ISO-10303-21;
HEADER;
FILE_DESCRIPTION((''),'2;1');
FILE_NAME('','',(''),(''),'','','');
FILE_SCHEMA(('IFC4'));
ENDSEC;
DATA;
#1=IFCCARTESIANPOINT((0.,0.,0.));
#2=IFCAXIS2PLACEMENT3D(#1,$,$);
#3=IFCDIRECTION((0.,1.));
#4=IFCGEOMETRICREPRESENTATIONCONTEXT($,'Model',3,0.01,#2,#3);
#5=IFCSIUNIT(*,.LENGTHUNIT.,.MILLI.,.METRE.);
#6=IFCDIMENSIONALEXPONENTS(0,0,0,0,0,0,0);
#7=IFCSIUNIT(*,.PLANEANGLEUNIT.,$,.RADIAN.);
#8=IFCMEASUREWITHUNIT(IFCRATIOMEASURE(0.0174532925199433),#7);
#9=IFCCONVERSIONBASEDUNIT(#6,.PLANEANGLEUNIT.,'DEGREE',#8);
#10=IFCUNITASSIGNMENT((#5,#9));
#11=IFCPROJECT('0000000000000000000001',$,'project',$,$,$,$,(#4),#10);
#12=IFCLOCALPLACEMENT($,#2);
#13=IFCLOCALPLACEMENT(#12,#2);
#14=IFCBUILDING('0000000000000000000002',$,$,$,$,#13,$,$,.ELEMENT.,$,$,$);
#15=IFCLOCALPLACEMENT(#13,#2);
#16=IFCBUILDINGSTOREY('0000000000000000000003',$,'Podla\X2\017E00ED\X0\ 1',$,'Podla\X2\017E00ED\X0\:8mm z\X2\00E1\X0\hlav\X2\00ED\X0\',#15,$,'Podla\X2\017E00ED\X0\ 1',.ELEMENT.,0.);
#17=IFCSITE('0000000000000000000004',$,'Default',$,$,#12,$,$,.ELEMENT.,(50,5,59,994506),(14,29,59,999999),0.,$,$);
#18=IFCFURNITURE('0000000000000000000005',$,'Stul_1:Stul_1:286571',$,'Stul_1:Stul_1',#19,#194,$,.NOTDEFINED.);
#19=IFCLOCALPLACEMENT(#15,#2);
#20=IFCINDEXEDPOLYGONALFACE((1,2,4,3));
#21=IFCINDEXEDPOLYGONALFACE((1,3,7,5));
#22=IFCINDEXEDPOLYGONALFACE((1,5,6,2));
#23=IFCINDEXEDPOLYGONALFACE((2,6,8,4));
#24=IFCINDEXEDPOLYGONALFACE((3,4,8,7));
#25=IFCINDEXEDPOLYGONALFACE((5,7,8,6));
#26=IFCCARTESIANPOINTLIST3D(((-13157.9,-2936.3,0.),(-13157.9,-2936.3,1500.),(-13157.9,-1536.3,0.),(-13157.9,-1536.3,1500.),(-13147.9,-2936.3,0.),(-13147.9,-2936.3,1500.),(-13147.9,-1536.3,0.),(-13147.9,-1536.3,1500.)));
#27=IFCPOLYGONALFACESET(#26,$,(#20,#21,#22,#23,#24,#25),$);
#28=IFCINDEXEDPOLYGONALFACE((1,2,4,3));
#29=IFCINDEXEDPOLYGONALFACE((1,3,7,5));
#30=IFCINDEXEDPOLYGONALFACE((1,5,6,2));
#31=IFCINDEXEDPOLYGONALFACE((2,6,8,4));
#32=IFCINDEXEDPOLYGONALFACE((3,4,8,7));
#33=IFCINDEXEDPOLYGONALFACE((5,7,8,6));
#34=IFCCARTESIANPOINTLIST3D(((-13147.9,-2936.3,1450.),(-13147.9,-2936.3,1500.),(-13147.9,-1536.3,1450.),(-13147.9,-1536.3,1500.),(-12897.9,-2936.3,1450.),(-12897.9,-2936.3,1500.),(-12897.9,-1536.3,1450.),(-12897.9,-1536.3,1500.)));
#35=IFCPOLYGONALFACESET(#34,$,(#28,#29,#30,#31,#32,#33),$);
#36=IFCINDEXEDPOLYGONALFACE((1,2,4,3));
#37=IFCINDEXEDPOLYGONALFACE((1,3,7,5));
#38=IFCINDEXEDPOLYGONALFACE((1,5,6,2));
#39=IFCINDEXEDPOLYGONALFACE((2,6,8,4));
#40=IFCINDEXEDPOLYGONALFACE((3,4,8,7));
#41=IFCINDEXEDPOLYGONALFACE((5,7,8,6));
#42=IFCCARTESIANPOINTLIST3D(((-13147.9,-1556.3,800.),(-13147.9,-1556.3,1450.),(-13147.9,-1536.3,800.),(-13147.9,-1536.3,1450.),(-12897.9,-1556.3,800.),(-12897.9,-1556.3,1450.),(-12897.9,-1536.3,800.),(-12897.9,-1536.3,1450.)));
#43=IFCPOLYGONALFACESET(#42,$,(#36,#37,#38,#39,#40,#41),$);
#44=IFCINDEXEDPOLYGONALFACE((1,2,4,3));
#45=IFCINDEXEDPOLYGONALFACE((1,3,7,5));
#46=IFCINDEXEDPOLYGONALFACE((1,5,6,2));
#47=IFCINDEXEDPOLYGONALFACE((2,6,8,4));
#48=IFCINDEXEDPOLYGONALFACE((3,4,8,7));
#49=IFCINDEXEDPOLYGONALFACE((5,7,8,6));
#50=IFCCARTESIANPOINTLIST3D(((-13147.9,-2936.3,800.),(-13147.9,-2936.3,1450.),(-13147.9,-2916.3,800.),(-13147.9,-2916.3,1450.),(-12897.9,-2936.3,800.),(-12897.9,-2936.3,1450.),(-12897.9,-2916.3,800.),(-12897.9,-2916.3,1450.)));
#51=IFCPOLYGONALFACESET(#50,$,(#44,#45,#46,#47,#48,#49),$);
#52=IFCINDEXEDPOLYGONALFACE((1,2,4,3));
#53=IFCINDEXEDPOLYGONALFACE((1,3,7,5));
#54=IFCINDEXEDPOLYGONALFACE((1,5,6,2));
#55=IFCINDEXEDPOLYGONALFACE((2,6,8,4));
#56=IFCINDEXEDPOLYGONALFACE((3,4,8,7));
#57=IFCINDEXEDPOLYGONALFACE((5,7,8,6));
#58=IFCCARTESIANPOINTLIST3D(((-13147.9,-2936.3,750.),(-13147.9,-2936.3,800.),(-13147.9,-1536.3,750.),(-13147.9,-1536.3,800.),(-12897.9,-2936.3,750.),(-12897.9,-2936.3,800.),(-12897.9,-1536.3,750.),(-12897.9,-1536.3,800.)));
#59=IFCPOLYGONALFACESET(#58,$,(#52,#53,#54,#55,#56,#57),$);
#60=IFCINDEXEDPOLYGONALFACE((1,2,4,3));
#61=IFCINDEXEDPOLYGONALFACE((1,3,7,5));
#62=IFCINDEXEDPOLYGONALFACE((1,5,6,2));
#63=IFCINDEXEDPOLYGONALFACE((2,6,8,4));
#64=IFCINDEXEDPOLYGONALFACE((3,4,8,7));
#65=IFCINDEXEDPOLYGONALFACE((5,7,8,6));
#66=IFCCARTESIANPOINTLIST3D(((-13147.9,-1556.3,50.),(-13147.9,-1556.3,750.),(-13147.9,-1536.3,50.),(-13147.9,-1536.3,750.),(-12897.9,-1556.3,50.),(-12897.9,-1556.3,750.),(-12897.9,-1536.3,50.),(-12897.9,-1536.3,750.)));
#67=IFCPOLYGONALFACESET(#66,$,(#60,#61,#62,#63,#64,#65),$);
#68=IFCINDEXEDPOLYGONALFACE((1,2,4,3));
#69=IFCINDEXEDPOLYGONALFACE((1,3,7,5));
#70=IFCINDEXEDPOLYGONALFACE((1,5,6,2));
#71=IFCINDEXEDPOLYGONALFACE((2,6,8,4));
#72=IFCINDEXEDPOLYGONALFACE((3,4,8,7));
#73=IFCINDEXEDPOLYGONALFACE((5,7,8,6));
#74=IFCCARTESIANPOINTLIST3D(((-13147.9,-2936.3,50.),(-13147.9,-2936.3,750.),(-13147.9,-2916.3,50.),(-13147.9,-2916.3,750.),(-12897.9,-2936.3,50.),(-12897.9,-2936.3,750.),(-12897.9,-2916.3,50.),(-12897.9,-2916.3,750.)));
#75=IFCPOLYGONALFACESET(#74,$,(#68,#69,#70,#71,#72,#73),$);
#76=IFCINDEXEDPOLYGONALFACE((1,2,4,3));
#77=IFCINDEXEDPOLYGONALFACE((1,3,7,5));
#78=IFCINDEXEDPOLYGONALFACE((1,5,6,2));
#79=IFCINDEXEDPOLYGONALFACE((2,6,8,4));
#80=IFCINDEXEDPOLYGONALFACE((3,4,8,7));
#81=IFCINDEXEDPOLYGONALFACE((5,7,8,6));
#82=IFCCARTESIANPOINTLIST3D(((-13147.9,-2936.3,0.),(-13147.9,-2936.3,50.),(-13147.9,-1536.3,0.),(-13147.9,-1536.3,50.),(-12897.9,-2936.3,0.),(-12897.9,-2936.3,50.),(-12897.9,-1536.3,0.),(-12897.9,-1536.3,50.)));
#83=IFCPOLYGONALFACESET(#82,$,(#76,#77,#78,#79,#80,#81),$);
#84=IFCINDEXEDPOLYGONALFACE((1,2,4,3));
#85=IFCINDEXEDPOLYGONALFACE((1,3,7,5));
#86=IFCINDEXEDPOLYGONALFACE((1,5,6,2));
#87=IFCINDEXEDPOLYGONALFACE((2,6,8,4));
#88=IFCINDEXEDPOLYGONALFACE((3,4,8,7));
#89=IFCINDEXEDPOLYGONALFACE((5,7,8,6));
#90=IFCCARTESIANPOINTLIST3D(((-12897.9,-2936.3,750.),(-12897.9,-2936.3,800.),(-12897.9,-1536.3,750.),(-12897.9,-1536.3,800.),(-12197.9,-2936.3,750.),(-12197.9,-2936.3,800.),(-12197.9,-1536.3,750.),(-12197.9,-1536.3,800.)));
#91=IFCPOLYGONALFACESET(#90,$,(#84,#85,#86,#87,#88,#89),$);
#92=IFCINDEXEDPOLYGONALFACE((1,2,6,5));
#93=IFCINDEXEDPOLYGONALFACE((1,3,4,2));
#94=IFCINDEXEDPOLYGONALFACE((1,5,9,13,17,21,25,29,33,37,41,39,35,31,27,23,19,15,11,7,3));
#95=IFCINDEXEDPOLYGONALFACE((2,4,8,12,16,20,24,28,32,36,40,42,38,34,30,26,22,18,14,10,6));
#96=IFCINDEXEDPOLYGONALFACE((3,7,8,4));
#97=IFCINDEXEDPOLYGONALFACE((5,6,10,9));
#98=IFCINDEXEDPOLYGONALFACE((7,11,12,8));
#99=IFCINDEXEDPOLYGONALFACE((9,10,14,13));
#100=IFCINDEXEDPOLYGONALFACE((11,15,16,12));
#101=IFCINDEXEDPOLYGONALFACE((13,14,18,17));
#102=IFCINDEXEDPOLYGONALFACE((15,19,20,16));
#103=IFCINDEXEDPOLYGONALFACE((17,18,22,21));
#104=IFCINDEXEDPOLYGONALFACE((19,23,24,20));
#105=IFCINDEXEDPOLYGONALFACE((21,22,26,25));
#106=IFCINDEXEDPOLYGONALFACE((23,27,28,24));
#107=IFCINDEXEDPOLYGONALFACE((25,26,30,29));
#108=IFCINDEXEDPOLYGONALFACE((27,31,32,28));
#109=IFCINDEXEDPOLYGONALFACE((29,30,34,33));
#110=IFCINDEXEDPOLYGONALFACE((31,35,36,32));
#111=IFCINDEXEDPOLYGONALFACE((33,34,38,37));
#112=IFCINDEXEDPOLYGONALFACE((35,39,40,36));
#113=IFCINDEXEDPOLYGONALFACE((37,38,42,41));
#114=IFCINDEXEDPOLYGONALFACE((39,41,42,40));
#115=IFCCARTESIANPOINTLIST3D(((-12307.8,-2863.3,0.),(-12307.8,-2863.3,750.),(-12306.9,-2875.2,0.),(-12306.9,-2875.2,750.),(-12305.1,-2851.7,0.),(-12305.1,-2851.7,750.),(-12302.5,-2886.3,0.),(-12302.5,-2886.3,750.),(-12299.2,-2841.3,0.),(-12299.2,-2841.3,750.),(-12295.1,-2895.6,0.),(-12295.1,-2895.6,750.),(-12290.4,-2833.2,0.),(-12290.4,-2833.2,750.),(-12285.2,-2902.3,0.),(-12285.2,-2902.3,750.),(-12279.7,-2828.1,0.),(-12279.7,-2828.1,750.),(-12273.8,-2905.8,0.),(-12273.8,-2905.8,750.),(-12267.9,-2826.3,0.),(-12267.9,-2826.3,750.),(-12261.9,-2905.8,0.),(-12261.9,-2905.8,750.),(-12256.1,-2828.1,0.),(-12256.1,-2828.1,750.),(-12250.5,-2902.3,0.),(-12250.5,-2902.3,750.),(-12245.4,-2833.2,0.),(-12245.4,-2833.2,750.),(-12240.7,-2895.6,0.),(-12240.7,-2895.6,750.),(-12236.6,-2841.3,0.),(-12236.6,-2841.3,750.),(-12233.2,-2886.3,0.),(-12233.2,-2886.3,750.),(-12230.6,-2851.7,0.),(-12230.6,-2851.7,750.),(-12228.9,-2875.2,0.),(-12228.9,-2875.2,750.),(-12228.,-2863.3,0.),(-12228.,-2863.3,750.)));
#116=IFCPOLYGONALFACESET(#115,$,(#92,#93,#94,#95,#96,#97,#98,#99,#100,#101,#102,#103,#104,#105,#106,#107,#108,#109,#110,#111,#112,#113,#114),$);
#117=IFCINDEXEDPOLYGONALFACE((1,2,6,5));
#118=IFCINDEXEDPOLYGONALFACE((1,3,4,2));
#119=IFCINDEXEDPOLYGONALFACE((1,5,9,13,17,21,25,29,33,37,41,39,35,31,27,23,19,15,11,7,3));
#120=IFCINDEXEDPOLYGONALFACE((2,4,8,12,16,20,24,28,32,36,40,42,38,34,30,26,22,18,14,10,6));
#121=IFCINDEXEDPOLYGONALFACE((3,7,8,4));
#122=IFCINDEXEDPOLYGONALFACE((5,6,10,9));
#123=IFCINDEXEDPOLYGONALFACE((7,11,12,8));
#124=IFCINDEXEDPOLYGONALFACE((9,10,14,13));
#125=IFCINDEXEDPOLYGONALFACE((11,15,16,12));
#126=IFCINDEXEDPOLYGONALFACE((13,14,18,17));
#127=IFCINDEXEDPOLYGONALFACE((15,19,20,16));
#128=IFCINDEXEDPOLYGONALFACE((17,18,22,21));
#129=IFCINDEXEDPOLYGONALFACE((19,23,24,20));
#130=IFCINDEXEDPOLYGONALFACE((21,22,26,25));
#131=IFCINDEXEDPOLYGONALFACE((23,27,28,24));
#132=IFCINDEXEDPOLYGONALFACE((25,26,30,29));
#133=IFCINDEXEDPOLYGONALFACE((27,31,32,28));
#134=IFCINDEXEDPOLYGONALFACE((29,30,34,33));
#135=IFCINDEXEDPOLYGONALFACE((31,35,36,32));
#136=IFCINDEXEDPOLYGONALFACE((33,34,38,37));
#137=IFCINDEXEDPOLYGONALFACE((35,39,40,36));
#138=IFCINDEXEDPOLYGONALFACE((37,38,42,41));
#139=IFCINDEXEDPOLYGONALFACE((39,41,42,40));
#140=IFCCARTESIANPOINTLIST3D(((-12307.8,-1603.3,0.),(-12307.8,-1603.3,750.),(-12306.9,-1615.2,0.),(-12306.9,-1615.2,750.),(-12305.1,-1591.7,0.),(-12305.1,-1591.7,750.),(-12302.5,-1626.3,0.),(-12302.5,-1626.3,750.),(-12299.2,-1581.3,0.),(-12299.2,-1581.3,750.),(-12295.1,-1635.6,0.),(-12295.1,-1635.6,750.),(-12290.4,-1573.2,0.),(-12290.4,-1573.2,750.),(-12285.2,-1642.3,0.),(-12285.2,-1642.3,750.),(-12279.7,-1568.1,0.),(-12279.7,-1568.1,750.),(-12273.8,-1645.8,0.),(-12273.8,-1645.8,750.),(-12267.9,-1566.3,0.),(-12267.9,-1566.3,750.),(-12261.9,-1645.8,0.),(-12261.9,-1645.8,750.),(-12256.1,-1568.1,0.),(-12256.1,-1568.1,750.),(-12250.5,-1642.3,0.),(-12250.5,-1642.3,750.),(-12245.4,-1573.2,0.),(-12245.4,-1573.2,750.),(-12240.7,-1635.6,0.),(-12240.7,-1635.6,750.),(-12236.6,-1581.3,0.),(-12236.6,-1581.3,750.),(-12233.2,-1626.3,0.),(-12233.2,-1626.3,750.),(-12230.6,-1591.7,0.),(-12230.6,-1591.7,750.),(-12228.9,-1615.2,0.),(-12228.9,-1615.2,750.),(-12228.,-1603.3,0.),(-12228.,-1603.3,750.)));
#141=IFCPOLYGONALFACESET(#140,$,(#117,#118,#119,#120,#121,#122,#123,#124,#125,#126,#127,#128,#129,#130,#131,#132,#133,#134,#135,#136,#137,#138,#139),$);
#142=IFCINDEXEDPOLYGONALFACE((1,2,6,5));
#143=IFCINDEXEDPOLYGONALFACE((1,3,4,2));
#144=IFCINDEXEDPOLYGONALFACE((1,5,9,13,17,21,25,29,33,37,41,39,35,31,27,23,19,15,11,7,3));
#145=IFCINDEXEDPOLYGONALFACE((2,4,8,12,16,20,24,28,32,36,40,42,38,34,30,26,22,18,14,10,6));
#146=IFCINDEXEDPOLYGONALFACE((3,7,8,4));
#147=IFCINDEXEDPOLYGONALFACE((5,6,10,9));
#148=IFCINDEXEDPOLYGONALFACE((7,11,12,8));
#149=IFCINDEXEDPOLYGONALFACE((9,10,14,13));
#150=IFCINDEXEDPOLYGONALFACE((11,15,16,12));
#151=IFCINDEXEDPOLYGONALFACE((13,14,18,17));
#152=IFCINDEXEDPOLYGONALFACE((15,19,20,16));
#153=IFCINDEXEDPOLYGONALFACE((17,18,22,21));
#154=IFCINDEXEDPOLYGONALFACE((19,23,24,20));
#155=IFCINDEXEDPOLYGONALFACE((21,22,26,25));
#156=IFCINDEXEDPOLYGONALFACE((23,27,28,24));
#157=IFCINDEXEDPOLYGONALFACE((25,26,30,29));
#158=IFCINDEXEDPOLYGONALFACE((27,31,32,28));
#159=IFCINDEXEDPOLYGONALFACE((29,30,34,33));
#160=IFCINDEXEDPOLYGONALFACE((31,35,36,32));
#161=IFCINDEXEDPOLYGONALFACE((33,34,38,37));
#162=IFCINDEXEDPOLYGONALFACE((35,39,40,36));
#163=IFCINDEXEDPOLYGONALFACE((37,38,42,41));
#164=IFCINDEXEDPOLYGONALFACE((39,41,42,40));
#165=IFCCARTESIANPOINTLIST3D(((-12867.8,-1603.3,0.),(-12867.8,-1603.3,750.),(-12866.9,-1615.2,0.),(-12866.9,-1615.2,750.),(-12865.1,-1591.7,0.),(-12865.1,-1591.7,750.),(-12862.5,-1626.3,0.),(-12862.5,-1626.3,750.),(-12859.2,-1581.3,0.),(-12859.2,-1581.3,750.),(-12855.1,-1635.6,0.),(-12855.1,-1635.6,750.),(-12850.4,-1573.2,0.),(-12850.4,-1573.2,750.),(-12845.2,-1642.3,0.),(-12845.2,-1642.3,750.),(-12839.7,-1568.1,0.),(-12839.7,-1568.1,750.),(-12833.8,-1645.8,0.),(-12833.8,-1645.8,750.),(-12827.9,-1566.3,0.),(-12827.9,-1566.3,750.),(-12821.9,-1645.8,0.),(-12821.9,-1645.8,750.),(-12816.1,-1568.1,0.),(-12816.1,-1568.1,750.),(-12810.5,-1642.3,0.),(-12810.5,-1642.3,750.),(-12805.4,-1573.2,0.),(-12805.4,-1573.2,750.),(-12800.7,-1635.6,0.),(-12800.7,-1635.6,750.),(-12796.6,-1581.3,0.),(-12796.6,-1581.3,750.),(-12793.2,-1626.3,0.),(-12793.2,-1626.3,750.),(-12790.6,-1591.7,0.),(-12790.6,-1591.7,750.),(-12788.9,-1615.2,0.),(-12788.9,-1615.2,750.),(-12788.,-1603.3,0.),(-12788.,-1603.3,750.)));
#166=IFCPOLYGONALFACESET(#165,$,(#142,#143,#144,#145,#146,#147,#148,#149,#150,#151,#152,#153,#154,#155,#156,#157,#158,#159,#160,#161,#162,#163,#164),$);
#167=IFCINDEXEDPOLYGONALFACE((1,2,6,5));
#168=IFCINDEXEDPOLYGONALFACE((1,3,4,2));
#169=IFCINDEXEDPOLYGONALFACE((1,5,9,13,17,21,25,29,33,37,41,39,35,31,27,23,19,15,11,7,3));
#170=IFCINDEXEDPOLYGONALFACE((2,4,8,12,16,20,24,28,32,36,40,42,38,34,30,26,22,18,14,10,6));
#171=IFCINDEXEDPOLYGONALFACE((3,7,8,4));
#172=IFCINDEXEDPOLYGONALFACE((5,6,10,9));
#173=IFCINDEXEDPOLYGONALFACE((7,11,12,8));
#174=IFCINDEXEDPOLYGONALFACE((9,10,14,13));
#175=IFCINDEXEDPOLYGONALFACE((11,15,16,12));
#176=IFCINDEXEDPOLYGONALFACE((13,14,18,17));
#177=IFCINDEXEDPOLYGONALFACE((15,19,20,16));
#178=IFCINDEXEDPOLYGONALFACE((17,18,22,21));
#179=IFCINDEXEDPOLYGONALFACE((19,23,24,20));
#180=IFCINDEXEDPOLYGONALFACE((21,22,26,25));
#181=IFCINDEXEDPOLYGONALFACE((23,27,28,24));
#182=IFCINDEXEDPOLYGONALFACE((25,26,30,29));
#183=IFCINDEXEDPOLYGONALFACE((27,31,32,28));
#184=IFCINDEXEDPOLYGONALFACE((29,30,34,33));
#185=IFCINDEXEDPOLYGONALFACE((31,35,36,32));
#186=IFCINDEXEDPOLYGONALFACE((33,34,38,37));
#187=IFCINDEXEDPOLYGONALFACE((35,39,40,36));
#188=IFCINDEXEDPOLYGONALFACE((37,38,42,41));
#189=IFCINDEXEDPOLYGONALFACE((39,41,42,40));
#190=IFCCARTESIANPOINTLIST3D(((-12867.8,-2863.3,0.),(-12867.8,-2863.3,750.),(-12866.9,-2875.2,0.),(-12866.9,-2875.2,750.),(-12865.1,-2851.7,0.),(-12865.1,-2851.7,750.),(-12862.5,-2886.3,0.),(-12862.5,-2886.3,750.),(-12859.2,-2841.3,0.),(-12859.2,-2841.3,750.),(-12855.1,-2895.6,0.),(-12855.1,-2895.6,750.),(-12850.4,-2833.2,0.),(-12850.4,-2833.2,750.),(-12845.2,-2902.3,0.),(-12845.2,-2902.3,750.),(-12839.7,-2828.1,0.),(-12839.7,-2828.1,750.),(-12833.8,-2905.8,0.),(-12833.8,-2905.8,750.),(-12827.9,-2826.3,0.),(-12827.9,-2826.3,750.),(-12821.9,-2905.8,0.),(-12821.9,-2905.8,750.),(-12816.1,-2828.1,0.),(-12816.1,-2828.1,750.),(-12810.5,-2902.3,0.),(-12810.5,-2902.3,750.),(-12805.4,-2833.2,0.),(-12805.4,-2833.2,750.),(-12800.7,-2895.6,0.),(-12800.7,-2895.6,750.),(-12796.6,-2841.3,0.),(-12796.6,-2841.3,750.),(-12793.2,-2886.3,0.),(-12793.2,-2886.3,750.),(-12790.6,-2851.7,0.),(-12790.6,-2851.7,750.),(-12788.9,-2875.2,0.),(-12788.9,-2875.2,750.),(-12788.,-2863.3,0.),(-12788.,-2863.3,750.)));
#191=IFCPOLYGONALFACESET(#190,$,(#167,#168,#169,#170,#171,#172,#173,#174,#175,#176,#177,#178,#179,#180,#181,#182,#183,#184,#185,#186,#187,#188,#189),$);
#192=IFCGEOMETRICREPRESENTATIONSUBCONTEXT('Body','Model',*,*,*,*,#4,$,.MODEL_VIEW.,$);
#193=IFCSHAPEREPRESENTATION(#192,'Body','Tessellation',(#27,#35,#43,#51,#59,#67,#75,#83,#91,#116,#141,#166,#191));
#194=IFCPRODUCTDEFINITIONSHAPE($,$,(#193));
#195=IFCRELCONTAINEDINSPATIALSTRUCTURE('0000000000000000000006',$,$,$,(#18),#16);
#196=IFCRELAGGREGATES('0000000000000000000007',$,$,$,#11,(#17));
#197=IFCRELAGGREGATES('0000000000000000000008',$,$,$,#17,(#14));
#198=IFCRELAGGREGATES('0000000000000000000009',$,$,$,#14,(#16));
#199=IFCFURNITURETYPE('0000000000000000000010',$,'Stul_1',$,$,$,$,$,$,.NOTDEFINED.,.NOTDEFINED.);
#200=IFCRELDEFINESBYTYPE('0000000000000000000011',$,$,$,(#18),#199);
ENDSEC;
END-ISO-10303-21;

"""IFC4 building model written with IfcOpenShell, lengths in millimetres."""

from ifc_helpers import new_model, entity, si_unit, converted_unit, direction, frame, frame_2d, origin, origin_2d_with_axis, place, context, subcontext, project, spatial, rectangle, circle, extrude, source, transform, mapped, type_object, type_shapes, element, save


model = new_model("IFC4")

# Units and contexts
model_context = context("Model", 3, precision=0.01, world=origin(), true_north=direction((0.0, 1.0)))
body_context = subcontext(model_context, "Body", "Model", "MODEL_VIEW")
ifc_project = project(units=[si_unit("LENGTHUNIT", "METRE", prefix="MILLI"), converted_unit("PLANEANGLEUNIT", "DEGREE", entity("IfcRatioMeasure", 0.0174532925199433), si_unit("PLANEANGLEUNIT", "RADIAN"), dimensions=[0, 0, 0, 0, 0, 0, 0])], contexts=[model_context])

# Site, building, storey
site_placement = place(None, origin())
site = spatial("IfcSite", under=ifc_project, at=site_placement, Name="Default", CompositionType="ELEMENT", RefLatitude=(50, 5, 59, 994506), RefLongitude=(14, 29, 59, 999999), RefElevation=0.0)
building_placement = place(site_placement, origin())
building = spatial("IfcBuilding", under=site, at=building_placement, CompositionType="ELEMENT")
storey_placement = place(building_placement, origin())
storey = spatial("IfcBuildingStorey", under=building, at=storey_placement, Name="Podlaží 1", ObjectType="Podlaží:8mm záhlaví", LongName="Podlaží 1", CompositionType="ELEMENT", Elevation=0.0)

# Furniture
furniture_type = type_object("IfcFurnitureType", Name="Stul_1", AssemblyPlace="NOTDEFINED", PredefinedType="NOTDEFINED")
shared_shape_1 = source(origin(), body_context, "Body", "SweptSolid", [
    extrude(rectangle(XDim=1400.0, YDim=10.0, at=origin_2d_with_axis()), frame((0.0, 605.0, 0.0), z_axis=(0.0, 0.0, 1.0), x_axis=(-1.0, 0.0, 0.0)), (0.0, 0.0, 1.0), 1500.0),
    extrude(rectangle(XDim=1400.0, YDim=250.0, at=frame_2d((0.0, 0.0), x_axis=(1.0, 0.0))), frame((0.0, 475.0, 1450.0), z_axis=(0.0, 0.0, 1.0), x_axis=(-1.0, 0.0, 0.0)), (0.0, 0.0, 1.0), 50.0),
    extrude(rectangle(XDim=20.0, YDim=250.0, at=origin_2d_with_axis()), frame((690.0, 475.0, 800.0), z_axis=(0.0, 0.0, 1.0), x_axis=(-1.0, 0.0, 0.0)), (0.0, 0.0, 1.0), 650.0),
    extrude(rectangle(XDim=20.0, YDim=250.0, at=frame_2d((0.0, 0.0), x_axis=(1.0, 0.0))), frame((-690.0, 475.0, 800.0), z_axis=(0.0, 0.0, 1.0), x_axis=(-1.0, 0.0, 0.0)), (0.0, 0.0, 1.0), 650.0),
    extrude(rectangle(XDim=1400.0, YDim=250.0, at=origin_2d_with_axis()), frame((0.0, 475.0, 750.0), z_axis=(0.0, 0.0, 1.0), x_axis=(-1.0, 0.0, 0.0)), (0.0, 0.0, 1.0), 50.0),
    extrude(rectangle(XDim=20.0, YDim=250.0, at=origin_2d_with_axis()), frame((690.0, 475.0, 50.0), z_axis=(0.0, 0.0, 1.0), x_axis=(-1.0, 0.0, 0.0)), (0.0, 0.0, 1.0), 700.0),
    extrude(rectangle(XDim=20.0, YDim=250.0, at=frame_2d((0.0, 0.0), x_axis=(1.0, 0.0))), frame((-690.0, 475.0, 50.0), z_axis=(0.0, 0.0, 1.0), x_axis=(-1.0, 0.0, 0.0)), (0.0, 0.0, 1.0), 700.0),
    extrude(rectangle(XDim=1400.0, YDim=250.0, at=origin_2d_with_axis()), frame((0.0, 475.0, 0.0), z_axis=(0.0, 0.0, 1.0), x_axis=(-1.0, 0.0, 0.0)), (0.0, 0.0, 1.0), 50.0),
    extrude(rectangle(XDim=1400.0, YDim=700.0, at=origin_2d_with_axis()), frame((0.0, 0.0, 750.0), z_axis=(0.0, 0.0, 1.0), x_axis=(-1.0, 0.0, 0.0)), (0.0, 0.0, 1.0), 50.0),
    extrude(circle(Radius=40.0, at=frame_2d((0.0, 0.0), x_axis=(1.0, 0.0))), frame((-630.0, -280.0, 0.0)), (0.0, 0.0, 1.0), 750.0),
    extrude(circle(Radius=40.0, at=frame_2d((0.0, 0.0), x_axis=(1.0, 0.0))), frame((630.0, -280.0, 0.0)), (0.0, 0.0, 1.0), 750.0),
    extrude(circle(Radius=40.0, at=frame_2d((0.0, 0.0), x_axis=(1.0, 0.0))), frame((630.0, 280.0, 0.0)), (0.0, 0.0, 1.0), 750.0),
    extrude(circle(Radius=40.0, at=frame_2d((0.0, 0.0), x_axis=(1.0, 0.0))), frame((-630.0, 280.0, 0.0)), (0.0, 0.0, 1.0), 750.0),
])
type_shapes(furniture_type, [shared_shape_1])
for number, where, z_axis, x_axis, name in (
    (1, (-12547.9, -2236.3, 0.0), (0.0, 0.0, 1.0), (0.0, 1.0, 0.0), "Stul_1:Stul_1:286571"),
):
    element("IfcFurniture", number, at=place(storey_placement, frame(where, z_axis=z_axis, x_axis=x_axis)), inside=storey, type_object=furniture_type, Name=name, ObjectType="Stul_1:Stul_1", PredefinedType="NOTDEFINED", context=body_context, shape_type="MappedRepresentation", body=[
        mapped(shared_shape_1, transform((0.0, 0.0, 0.0), scale=1.0)),
    ])

save(model, "model.ifc")
